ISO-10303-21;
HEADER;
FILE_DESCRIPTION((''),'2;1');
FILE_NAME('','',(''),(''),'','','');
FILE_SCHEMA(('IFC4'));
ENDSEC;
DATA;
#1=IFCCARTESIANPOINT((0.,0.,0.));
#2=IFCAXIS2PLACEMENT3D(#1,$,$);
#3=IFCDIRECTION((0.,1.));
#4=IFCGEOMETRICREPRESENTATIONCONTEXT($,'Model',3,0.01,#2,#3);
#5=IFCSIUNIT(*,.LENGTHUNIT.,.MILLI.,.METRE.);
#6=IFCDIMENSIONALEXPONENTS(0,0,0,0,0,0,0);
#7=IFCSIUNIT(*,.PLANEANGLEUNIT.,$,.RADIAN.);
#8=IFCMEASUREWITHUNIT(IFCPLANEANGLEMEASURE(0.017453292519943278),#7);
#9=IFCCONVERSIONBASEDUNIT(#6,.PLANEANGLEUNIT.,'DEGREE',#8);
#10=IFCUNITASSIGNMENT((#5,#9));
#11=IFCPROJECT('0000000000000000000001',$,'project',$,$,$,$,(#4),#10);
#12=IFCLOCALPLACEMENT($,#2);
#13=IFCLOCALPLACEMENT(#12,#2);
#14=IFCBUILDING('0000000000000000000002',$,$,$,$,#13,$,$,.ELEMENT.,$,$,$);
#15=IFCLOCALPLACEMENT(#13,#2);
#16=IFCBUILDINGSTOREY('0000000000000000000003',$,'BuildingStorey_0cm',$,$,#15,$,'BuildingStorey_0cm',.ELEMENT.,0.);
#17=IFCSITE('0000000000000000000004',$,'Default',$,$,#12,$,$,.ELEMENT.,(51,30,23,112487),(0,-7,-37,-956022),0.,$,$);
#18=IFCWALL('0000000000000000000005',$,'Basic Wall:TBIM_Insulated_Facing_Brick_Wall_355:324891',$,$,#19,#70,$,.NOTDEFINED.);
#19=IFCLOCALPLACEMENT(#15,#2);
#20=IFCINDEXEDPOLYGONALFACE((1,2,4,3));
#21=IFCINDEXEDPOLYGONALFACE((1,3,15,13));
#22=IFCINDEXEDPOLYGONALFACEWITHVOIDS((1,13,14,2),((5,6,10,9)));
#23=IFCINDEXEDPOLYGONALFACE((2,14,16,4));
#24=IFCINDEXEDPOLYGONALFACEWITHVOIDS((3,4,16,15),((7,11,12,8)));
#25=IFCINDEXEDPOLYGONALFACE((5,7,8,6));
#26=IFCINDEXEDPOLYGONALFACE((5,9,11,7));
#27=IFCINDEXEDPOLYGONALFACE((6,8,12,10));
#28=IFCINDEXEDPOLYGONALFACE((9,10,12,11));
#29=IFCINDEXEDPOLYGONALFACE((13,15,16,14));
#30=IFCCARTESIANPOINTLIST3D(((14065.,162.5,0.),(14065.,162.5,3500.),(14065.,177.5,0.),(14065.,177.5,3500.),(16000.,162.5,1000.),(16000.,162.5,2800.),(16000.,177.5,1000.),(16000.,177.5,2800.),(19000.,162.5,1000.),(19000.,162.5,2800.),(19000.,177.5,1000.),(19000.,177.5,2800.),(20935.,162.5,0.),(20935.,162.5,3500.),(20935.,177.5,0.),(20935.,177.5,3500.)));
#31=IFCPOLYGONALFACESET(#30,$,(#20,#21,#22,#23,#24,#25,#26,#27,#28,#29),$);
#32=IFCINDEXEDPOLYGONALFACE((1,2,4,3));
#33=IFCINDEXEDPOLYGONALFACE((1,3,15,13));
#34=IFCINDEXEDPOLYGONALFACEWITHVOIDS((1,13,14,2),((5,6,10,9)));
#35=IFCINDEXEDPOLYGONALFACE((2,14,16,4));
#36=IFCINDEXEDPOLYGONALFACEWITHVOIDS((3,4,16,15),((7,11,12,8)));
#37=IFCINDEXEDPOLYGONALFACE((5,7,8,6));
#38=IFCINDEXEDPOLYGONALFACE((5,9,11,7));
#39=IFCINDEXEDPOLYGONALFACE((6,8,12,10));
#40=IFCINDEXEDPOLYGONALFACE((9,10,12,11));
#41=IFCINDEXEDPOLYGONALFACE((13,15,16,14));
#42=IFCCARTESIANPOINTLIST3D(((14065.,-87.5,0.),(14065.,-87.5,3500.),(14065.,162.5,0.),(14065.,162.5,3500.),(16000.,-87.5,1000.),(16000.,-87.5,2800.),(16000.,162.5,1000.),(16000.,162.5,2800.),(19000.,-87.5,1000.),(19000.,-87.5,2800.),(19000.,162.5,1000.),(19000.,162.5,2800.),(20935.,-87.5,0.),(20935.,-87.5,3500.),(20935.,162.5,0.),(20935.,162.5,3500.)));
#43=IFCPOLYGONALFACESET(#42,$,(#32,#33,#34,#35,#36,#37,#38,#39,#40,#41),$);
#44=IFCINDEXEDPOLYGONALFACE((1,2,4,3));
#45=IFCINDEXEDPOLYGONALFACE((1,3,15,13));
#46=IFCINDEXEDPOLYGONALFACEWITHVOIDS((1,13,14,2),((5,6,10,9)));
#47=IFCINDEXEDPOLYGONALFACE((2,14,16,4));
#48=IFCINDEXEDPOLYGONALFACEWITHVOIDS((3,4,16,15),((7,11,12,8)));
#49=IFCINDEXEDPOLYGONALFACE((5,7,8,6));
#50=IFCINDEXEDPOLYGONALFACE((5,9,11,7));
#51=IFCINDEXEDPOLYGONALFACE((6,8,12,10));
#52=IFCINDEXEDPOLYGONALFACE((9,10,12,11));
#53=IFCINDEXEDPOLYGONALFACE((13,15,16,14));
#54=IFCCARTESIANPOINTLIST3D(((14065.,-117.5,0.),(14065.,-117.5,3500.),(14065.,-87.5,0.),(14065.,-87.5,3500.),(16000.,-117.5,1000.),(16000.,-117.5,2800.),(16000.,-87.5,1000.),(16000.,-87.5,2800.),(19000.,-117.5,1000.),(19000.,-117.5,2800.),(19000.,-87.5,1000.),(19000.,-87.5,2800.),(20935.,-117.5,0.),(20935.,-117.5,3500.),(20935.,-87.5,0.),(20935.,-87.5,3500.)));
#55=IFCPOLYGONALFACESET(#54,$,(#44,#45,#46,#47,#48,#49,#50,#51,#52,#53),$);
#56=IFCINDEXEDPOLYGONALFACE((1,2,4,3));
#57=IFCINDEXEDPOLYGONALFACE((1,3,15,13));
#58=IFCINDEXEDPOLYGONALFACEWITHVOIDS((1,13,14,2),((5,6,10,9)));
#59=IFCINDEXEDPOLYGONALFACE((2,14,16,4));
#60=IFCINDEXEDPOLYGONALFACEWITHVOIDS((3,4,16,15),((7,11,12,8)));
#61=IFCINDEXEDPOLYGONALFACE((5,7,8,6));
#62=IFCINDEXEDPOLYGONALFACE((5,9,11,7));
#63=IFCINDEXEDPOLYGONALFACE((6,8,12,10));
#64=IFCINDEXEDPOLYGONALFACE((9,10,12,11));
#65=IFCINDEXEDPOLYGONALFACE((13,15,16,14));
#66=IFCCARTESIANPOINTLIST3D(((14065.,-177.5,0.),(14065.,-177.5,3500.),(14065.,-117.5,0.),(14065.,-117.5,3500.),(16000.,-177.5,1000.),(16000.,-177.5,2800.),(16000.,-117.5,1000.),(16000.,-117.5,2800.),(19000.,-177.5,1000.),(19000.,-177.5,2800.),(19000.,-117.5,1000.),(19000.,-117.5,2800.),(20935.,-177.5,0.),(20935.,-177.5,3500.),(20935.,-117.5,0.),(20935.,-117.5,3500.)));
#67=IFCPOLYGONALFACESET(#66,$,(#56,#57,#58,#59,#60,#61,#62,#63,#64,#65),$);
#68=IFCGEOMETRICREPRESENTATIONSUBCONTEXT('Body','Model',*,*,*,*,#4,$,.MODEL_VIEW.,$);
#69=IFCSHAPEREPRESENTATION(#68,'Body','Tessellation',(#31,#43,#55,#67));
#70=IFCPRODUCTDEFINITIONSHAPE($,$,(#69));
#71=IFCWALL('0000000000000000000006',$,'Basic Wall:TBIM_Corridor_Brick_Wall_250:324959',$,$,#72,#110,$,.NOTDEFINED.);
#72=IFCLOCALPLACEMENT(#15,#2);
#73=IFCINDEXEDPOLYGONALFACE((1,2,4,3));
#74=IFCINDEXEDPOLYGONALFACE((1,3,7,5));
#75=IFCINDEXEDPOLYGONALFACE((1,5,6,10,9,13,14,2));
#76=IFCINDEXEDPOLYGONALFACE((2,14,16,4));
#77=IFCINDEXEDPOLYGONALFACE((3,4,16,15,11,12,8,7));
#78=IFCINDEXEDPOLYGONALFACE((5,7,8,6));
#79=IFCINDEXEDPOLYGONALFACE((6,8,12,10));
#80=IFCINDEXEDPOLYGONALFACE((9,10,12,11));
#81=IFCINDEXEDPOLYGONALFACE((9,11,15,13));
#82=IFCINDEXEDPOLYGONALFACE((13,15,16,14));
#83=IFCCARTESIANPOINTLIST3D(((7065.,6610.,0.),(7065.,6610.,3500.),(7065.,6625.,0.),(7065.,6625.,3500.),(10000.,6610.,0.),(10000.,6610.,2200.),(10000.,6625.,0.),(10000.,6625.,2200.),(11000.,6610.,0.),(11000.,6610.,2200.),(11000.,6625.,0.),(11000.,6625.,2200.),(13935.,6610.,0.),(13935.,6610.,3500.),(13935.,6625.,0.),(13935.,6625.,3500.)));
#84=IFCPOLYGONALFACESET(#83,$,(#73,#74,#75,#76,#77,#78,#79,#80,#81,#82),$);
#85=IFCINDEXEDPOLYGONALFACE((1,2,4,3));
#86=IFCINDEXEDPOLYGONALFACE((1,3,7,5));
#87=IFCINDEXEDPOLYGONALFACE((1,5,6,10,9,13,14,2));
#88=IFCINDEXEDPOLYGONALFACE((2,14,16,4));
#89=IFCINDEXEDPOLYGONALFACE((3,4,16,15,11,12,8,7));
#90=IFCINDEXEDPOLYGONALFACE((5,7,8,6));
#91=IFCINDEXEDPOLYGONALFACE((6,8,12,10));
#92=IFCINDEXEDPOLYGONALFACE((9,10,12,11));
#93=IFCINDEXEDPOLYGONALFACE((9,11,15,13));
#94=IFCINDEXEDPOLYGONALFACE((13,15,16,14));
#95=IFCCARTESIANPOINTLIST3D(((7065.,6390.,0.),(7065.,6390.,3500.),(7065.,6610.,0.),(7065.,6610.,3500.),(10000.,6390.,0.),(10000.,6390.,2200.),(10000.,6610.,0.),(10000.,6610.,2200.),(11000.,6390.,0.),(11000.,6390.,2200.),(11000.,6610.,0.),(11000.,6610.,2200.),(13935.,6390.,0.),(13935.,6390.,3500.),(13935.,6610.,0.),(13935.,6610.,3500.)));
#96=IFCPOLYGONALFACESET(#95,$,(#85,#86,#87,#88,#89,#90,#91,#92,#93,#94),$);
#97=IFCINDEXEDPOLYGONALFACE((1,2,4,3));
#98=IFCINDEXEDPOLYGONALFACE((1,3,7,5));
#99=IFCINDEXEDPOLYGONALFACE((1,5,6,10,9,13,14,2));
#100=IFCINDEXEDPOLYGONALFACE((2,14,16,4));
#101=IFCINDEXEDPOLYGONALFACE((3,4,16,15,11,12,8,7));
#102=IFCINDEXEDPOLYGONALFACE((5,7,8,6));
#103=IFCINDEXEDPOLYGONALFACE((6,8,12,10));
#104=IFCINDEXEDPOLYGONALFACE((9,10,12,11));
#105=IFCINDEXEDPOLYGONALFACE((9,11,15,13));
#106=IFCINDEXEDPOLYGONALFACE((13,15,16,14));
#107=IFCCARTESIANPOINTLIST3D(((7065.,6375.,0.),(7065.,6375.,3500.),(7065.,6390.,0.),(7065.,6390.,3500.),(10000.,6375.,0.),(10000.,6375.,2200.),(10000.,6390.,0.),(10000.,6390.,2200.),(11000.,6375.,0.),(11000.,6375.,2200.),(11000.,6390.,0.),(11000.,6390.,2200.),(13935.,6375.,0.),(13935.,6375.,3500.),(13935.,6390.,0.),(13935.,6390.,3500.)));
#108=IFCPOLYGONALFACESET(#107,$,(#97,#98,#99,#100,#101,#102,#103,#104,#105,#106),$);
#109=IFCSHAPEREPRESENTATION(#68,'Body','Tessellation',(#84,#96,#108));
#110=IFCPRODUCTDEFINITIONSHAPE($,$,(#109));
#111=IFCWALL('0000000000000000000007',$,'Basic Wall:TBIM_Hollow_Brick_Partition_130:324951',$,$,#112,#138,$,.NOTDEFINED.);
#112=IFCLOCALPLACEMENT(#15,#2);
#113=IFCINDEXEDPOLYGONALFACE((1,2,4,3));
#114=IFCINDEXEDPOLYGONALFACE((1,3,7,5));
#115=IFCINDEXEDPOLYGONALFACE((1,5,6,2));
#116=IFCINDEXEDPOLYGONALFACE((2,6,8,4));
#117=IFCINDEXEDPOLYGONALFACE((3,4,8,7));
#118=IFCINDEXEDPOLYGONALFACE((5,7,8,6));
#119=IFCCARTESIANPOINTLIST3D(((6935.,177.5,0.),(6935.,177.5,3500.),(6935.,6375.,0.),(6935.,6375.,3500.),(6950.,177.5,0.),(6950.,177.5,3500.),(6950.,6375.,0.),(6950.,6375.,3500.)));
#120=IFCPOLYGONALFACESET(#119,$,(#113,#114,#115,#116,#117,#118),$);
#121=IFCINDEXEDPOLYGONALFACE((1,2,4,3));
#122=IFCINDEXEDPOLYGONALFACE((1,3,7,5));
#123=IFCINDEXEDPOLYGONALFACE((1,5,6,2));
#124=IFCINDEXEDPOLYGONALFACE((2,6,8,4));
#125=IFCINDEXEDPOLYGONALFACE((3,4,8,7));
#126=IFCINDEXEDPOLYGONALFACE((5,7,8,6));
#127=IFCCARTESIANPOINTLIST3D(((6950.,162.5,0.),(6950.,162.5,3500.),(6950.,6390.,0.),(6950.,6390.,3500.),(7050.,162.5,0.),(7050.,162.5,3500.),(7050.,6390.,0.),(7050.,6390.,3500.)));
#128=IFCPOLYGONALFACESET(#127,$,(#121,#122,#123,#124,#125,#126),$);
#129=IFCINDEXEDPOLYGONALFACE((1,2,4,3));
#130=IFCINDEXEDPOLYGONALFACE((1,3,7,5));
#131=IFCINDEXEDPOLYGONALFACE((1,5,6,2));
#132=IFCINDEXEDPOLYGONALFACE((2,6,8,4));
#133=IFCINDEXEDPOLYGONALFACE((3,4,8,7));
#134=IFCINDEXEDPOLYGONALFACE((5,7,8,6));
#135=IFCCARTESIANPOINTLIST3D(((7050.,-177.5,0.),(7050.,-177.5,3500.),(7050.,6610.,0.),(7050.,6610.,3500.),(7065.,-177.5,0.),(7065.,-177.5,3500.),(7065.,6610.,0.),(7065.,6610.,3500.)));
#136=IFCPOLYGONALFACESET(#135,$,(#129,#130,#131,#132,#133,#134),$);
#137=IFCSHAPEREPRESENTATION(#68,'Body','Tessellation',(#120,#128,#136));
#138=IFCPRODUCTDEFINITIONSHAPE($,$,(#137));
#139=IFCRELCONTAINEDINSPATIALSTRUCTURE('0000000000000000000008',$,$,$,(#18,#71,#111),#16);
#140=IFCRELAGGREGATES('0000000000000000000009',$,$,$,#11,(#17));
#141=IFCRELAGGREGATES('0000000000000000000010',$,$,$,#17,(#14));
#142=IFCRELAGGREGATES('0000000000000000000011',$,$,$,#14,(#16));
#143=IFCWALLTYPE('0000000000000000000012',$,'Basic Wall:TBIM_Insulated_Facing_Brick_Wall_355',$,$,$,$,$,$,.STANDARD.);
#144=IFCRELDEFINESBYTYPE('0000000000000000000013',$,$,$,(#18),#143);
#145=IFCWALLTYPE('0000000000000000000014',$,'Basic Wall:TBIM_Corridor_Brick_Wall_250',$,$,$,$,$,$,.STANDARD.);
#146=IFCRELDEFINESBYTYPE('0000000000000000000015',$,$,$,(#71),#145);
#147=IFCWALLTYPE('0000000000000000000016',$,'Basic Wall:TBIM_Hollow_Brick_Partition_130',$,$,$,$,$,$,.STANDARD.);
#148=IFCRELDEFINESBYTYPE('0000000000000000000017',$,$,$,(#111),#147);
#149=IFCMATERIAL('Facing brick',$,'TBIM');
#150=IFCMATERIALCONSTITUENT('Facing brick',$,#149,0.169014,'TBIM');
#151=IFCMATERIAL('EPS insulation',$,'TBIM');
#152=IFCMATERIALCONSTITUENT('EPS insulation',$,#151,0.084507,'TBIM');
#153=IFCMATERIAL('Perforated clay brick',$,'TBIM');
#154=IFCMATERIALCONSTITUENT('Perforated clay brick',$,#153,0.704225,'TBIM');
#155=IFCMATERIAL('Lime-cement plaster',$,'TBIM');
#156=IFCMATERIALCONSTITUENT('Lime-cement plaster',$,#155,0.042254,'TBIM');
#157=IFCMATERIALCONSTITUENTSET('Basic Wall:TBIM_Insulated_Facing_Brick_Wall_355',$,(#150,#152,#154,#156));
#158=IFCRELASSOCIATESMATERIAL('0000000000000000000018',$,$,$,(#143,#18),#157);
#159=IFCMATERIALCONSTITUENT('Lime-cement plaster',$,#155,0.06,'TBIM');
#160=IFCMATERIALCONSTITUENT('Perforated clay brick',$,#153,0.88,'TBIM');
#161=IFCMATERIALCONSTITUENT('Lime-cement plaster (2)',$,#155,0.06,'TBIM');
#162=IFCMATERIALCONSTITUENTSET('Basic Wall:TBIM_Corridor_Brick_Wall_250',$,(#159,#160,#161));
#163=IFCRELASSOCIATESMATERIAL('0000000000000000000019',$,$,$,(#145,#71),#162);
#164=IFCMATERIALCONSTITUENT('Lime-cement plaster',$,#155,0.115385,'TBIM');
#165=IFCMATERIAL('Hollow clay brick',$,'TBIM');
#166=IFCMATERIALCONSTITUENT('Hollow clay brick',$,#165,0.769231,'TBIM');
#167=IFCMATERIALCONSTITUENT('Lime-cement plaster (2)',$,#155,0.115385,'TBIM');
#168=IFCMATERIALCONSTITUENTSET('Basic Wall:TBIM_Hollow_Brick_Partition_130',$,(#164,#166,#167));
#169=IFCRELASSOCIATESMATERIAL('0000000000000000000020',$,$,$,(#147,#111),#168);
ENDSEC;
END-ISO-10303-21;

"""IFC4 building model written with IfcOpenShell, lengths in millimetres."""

from ifc_helpers import new_model, entity, si_unit, converted_unit, direction, frame, origin, place, context, subcontext, project, spatial, indexed_curve, outline, extrude, material, constituent, constituent_set, type_object, element, save


model = new_model("IFC4")

# Units and contexts
model_context = context("Model", 3, precision=0.01, world=origin(), true_north=direction((0.0, 1.0)))
body_context = subcontext(model_context, "Body", "Model", "MODEL_VIEW")
ifc_project = project(units=[si_unit("LENGTHUNIT", "METRE", prefix="MILLI"), converted_unit("PLANEANGLEUNIT", "DEGREE", entity("IfcPlaneAngleMeasure", 0.017453292519943278), si_unit("PLANEANGLEUNIT", "RADIAN"), dimensions=[0, 0, 0, 0, 0, 0, 0])], contexts=[model_context])

# Site, building, storey
site_placement = place(None, origin())
site = spatial("IfcSite", under=ifc_project, at=site_placement, Name="Default", CompositionType="ELEMENT", RefLatitude=(51, 30, 23, 112487), RefLongitude=(0, -7, -37, -956022), RefElevation=0.0)
building_placement = place(site_placement, origin())
building = spatial("IfcBuilding", under=site, at=building_placement, CompositionType="ELEMENT")
storey_placement = place(building_placement, origin())
storey = spatial("IfcBuildingStorey", under=building, at=storey_placement, Name="BuildingStorey_0cm", LongName="BuildingStorey_0cm", CompositionType="ELEMENT", Elevation=0.0)

# Walls, openings
ifc_material_1 = material(Name="Facing brick", Category="TBIM")
ifc_constituent_1 = constituent(ifc_material_1, Name="Facing brick", Category="TBIM", fraction=0.169014)
ifc_material_2 = material(Name="EPS insulation", Category="TBIM")
ifc_constituent_2 = constituent(ifc_material_2, Name="EPS insulation", Category="TBIM", fraction=0.084507)
ifc_material_3 = material(Name="Perforated clay brick", Category="TBIM")
ifc_constituent_3 = constituent(ifc_material_3, Name="Perforated clay brick", Category="TBIM", fraction=0.704225)
ifc_material_4 = material(Name="Lime-cement plaster", Category="TBIM")
ifc_constituent_4 = constituent(ifc_material_4, Name="Lime-cement plaster", Category="TBIM", fraction=0.042254)
ifc_constituent_set_1 = constituent_set(constituents=[ifc_constituent_1, ifc_constituent_2, ifc_constituent_3, ifc_constituent_4], Name="Basic Wall:TBIM_Insulated_Facing_Brick_Wall_355")
wall_type_1 = type_object("IfcWallType", Name="Basic Wall:TBIM_Insulated_Facing_Brick_Wall_355", PredefinedType="STANDARD", material=ifc_constituent_set_1)
wall_1_placement = place(storey_placement, frame((14065.0, 0.0, 0.0)))
wall_1 = element("IfcWall", 1, at=wall_1_placement, inside=storey, type_object=wall_type_1, material=ifc_constituent_set_1, Name="Basic Wall:TBIM_Insulated_Facing_Brick_Wall_355:324891", PredefinedType="NOTDEFINED", context=body_context, shape_type="SweptSolid", body=[
    extrude(outline(indexed_curve([(-1750.0, -3435.0), (1750.0, -3435.0), (1750.0, 3435.0), (-1750.0, 3435.0), (-1750.0, -3435.0)], self_intersect=False), holes=[indexed_curve([(-750.0, -1500.0), (-750.0, 1500.0), (1050.0, 1500.0), (1050.0, -1500.0), (-750.0, -1500.0)], self_intersect=False)]), frame((3435.0, 162.5, 1750.0), z_axis=(0.0, 1.0, 0.0), x_axis=(0.0, 0.0, 1.0)), (0.0, 0.0, 1.0), 15.0),
    extrude(outline(indexed_curve([(-1750.0, -3435.0), (1750.0, -3435.0), (1750.0, 3435.0), (-1750.0, 3435.0), (-1750.0, -3435.0)], self_intersect=False), holes=[indexed_curve([(-750.0, -1500.0), (-750.0, 1500.0), (1050.0, 1500.0), (1050.0, -1500.0), (-750.0, -1500.0)], self_intersect=False)]), frame((3435.0, -87.5, 1750.0), z_axis=(0.0, 1.0, 0.0), x_axis=(0.0, 0.0, 1.0)), (0.0, 0.0, 1.0), 250.0),
    extrude(outline(indexed_curve([(-1750.0, -3435.0), (1750.0, -3435.0), (1750.0, 3435.0), (-1750.0, 3435.0), (-1750.0, -3435.0)], self_intersect=False), holes=[indexed_curve([(-750.0, -1500.0), (-750.0, 1500.0), (1050.0, 1500.0), (1050.0, -1500.0), (-750.0, -1500.0)], self_intersect=False)]), frame((3435.0, -117.5, 1750.0), z_axis=(0.0, 1.0, 0.0), x_axis=(0.0, 0.0, 1.0)), (0.0, 0.0, 1.0), 30.0),
    extrude(outline(indexed_curve([(-1750.0, -3435.0), (1750.0, -3435.0), (1750.0, 3435.0), (-1750.0, 3435.0), (-1750.0, -3435.0)], self_intersect=False), holes=[indexed_curve([(1050.0, -1500.0), (-750.0, -1500.0), (-750.0, 1500.0), (1050.0, 1500.0), (1050.0, -1500.0)], self_intersect=False)]), frame((3435.0, -177.5, 1750.0), z_axis=(0.0, 1.0, 0.0), x_axis=(0.0, 0.0, 1.0)), (0.0, 0.0, 1.0), 60.0),
])
opening_1_placement = place(wall_1_placement, frame((1935.0, -177.5, 1000.0)))
element("IfcOpeningElement", 2, at=opening_1_placement, cuts=wall_1, PredefinedType="OPENING", context=body_context, shape_type="SweptSolid", body=[
    extrude(outline(indexed_curve([(1800.0, 0.0), (1800.0, 3000.0), (0.0, 3000.0), (0.0, 0.0), (1800.0, 0.0)], self_intersect=False)), frame((0.0, 0.0, 0.0), z_axis=(0.0, 1.0, 0.0), x_axis=(0.0, 0.0, 1.0)), (0.0, 0.0, 1.0), 355.0),
])
ifc_constituent_5 = constituent(ifc_material_4, Name="Lime-cement plaster", Category="TBIM", fraction=0.06)
ifc_constituent_6 = constituent(ifc_material_3, Name="Perforated clay brick", Category="TBIM", fraction=0.88)
ifc_constituent_7 = constituent(ifc_material_4, Name="Lime-cement plaster (2)", Category="TBIM", fraction=0.06)
ifc_constituent_set_2 = constituent_set(constituents=[ifc_constituent_5, ifc_constituent_6, ifc_constituent_7], Name="Basic Wall:TBIM_Corridor_Brick_Wall_250")
wall_type_2 = type_object("IfcWallType", Name="Basic Wall:TBIM_Corridor_Brick_Wall_250", PredefinedType="STANDARD", material=ifc_constituent_set_2)
wall_2_placement = place(storey_placement, frame((7065.0, 6500.0, 0.0)))
wall_2 = element("IfcWall", 3, at=wall_2_placement, inside=storey, type_object=wall_type_2, material=ifc_constituent_set_2, Name="Basic Wall:TBIM_Corridor_Brick_Wall_250:324959", PredefinedType="NOTDEFINED", context=body_context, shape_type="SweptSolid", body=[
    extrude(outline(indexed_curve([(-1425.0, -3435.0), (2075.0, -3435.0), (2075.0, 3435.0), (-1425.0, 3435.0), (-1425.0, 500.0), (775.0, 500.0), (775.0, -500.0), (-1425.0, -500.0), (-1425.0, -3435.0)], self_intersect=False)), frame((3435.0, 110.0, 1425.0), z_axis=(0.0, 1.0, 0.0), x_axis=(0.0, 0.0, 1.0)), (0.0, 0.0, 1.0), 15.0),
    extrude(outline(indexed_curve([(-1425.0, -3435.0), (2075.0, -3435.0), (2075.0, 3435.0), (-1425.0, 3435.0), (-1425.0, 500.0), (775.0, 500.0), (775.0, -500.0), (-1425.0, -500.0), (-1425.0, -3435.0)], self_intersect=False)), frame((3435.0, -110.0, 1425.0), z_axis=(0.0, 1.0, 0.0), x_axis=(0.0, 0.0, 1.0)), (0.0, 0.0, 1.0), 220.0),
    extrude(outline(indexed_curve([(-2075.0, -3435.0), (1425.0, -3435.0), (1425.0, -500.0), (-775.0, -500.0), (-775.0, 500.0), (1425.0, 500.0), (1425.0, 3435.0), (-2075.0, 3435.0), (-2075.0, -3435.0)], self_intersect=False)), frame((3435.0, -125.0, 1425.0), z_axis=(0.0, 1.0, 0.0), x_axis=(0.0, 0.0, -1.0)), (0.0, 0.0, 1.0), 15.0),
])
opening_2_placement = place(wall_2_placement, frame((2935.0, -125.0, 0.0)))
element("IfcOpeningElement", 4, at=opening_2_placement, cuts=wall_2, PredefinedType="OPENING", context=body_context, shape_type="SweptSolid", body=[
    extrude(outline(indexed_curve([(0.0, 1000.0), (0.0, 0.0), (2200.0, 0.0), (2200.0, 1000.0), (0.0, 1000.0)], self_intersect=False)), frame((0.0, 0.0, 0.0), z_axis=(0.0, 1.0, 0.0), x_axis=(0.0, 0.0, 1.0)), (0.0, 0.0, 1.0), 250.0),
])

# Wall
ifc_constituent_8 = constituent(ifc_material_4, Name="Lime-cement plaster", Category="TBIM", fraction=0.115385)
ifc_material_5 = material(Name="Hollow clay brick", Category="TBIM")
ifc_constituent_9 = constituent(ifc_material_5, Name="Hollow clay brick", Category="TBIM", fraction=0.769231)
ifc_constituent_10 = constituent(ifc_material_4, Name="Lime-cement plaster (2)", Category="TBIM", fraction=0.115385)
ifc_constituent_set_3 = constituent_set(constituents=[ifc_constituent_8, ifc_constituent_9, ifc_constituent_10], Name="Basic Wall:TBIM_Hollow_Brick_Partition_130")
wall_type_3 = type_object("IfcWallType", Name="Basic Wall:TBIM_Hollow_Brick_Partition_130", PredefinedType="STANDARD", material=ifc_constituent_set_3)
wall_3_placement = place(storey_placement, frame((7000.0, 177.5, 0.0), z_axis=(0.0, 0.0, 1.0), x_axis=(0.0, 1.0, 0.0)))
element("IfcWall", 5, at=wall_3_placement, inside=storey, type_object=wall_type_3, material=ifc_constituent_set_3, Name="Basic Wall:TBIM_Hollow_Brick_Partition_130:324951", PredefinedType="NOTDEFINED", context=body_context, shape_type="SweptSolid", body=[
    extrude(outline(indexed_curve([(-7.5, -3098.8), (7.5, -3098.8), (7.5, 3098.8), (-7.5, 3098.8), (-7.5, -3098.8)], self_intersect=False)), frame((3098.8, 57.5, 0.0), z_axis=(0.0, 0.0, 1.0), x_axis=(0.0, -1.0, 0.0)), (0.0, 0.0, 1.0), 3500.0),
    extrude(outline(indexed_curve([(-3113.8, -50.0), (3113.8, -50.0), (3113.8, 50.0), (-3113.8, 50.0), (-3113.8, -50.0)], self_intersect=False)), frame((3098.8, 0.0, 0.0)), (0.0, 0.0, 1.0), 3500.0),
    extrude(outline(indexed_curve([(-7.5, -3393.8), (7.5, -3393.8), (7.5, 3393.7), (-7.5, 3393.7), (-7.5, -3393.8)], self_intersect=False)), frame((3038.7, -57.5, 0.0), z_axis=(0.0, 0.0, 1.0), x_axis=(0.0, 1.0, 0.0)), (0.0, 0.0, 1.0), 3500.0),
])

save(model, "model.ifc")
